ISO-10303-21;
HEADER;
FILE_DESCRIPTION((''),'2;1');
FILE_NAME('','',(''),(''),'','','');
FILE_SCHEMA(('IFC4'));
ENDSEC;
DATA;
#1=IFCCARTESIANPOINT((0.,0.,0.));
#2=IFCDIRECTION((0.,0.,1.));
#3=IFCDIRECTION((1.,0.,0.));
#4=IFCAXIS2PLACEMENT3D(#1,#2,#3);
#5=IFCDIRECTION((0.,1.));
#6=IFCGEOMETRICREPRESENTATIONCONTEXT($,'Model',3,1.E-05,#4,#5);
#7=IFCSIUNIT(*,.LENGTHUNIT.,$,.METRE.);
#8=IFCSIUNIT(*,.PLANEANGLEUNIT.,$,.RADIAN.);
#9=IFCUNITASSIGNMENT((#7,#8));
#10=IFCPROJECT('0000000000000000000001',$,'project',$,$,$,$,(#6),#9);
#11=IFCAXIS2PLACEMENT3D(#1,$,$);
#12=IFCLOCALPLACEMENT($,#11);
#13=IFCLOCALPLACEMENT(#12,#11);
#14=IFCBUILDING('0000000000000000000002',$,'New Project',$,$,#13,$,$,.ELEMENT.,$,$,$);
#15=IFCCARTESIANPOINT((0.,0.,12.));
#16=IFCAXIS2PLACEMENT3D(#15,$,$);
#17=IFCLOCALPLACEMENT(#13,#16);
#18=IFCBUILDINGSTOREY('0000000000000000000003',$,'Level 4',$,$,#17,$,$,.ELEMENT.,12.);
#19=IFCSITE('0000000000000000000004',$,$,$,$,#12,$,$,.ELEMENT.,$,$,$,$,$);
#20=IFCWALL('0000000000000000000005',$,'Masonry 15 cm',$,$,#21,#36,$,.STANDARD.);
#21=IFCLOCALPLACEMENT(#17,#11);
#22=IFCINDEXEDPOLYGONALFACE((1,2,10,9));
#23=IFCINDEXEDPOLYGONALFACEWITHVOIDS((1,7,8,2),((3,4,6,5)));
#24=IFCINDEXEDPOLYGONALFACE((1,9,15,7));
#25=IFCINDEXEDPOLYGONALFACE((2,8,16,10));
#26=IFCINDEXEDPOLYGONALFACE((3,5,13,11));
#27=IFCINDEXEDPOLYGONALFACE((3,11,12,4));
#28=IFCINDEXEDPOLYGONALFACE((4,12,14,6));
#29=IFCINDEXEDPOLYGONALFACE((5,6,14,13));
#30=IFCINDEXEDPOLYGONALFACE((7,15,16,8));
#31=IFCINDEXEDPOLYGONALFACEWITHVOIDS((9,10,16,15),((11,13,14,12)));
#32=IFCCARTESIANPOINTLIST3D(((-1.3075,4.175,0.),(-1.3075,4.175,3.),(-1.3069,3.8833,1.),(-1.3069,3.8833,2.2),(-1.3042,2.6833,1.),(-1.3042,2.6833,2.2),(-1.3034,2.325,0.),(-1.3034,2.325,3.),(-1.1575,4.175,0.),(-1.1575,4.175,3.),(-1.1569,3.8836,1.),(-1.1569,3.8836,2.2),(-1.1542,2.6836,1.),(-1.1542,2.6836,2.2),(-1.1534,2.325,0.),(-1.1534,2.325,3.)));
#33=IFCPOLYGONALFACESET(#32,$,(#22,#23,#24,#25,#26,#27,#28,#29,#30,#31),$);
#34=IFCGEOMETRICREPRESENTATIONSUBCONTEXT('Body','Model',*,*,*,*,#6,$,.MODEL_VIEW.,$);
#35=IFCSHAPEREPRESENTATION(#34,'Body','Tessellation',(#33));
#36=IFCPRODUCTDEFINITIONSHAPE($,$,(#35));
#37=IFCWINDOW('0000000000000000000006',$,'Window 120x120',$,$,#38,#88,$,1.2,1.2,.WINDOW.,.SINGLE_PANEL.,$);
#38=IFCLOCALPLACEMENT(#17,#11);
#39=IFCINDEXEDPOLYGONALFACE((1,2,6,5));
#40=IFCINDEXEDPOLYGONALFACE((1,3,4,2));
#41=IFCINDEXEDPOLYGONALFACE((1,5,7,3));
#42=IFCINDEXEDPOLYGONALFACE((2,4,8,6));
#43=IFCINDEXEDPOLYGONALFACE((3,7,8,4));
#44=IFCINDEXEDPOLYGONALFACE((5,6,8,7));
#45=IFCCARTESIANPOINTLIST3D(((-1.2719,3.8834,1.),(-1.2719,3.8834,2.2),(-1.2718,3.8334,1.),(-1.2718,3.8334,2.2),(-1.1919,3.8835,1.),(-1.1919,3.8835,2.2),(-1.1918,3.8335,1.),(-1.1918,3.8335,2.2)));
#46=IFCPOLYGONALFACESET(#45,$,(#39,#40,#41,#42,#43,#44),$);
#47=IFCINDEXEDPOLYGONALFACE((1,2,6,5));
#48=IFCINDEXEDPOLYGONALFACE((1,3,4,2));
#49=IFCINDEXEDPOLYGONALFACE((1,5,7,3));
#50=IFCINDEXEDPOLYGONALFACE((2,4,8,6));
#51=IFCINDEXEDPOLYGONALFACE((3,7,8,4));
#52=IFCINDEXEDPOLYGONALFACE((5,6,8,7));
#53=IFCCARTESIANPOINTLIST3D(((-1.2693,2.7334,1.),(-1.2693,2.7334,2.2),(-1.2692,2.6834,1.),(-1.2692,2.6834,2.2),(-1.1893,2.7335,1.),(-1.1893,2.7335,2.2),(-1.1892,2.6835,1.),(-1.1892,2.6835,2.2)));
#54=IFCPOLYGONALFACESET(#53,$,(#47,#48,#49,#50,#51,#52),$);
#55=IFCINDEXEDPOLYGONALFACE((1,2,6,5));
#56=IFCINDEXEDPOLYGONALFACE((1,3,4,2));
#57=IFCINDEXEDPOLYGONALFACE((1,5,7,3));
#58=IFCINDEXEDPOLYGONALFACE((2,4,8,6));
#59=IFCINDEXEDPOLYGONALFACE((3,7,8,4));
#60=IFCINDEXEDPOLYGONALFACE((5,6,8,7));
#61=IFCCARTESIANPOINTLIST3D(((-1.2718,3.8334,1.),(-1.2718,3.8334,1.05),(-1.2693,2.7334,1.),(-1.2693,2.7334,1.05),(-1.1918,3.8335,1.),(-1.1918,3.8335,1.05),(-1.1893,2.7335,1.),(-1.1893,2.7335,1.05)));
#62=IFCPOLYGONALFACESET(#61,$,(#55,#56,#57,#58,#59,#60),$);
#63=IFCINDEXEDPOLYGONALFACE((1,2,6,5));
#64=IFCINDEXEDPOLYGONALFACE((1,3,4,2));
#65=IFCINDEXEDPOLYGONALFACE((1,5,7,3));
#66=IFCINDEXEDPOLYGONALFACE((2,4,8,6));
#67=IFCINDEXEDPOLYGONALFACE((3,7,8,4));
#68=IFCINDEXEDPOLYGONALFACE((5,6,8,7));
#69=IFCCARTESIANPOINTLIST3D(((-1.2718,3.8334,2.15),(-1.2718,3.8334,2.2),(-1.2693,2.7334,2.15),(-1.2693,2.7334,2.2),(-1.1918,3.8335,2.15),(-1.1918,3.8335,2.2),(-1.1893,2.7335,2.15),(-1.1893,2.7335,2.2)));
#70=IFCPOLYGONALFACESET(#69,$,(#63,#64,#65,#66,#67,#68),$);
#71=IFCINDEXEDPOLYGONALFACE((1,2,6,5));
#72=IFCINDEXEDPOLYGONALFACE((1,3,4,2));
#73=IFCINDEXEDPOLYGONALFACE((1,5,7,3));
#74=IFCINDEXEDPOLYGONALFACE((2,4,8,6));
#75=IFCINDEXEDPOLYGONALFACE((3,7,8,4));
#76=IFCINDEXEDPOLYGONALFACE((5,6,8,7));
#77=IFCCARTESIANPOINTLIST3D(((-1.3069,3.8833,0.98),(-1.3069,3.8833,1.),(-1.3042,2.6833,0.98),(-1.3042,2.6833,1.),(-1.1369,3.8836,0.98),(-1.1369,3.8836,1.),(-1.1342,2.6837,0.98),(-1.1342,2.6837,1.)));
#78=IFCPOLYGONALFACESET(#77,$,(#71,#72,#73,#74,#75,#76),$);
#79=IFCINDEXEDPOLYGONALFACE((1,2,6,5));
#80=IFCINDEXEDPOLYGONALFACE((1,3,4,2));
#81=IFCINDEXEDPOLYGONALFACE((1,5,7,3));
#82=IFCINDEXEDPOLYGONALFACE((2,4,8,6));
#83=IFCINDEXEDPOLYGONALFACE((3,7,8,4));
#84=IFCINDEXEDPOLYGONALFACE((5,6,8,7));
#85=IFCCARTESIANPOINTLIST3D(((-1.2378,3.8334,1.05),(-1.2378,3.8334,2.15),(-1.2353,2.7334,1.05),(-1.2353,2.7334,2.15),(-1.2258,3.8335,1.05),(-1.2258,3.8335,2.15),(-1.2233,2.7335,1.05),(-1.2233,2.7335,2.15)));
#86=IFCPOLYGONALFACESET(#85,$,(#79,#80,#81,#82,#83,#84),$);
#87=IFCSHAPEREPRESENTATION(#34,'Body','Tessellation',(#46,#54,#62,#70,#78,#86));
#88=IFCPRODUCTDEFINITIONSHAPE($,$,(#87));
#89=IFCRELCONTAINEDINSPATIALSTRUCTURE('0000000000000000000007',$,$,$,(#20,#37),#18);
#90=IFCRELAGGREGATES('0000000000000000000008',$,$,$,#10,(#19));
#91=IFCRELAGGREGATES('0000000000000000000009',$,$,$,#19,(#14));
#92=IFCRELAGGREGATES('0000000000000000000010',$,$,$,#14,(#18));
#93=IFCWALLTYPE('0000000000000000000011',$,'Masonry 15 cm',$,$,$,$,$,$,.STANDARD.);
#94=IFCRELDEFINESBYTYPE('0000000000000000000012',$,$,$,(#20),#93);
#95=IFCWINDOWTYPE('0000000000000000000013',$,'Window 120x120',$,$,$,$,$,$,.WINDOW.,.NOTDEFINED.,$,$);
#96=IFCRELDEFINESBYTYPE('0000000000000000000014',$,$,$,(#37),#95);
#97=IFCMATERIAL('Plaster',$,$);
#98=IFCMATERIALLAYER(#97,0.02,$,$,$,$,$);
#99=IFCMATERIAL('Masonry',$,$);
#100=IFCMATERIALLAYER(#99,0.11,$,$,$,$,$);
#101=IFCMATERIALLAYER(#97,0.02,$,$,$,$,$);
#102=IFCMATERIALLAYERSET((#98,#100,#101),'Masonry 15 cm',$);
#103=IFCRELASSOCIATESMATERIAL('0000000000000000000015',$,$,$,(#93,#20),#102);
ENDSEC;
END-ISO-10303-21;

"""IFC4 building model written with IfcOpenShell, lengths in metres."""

from ifc_helpers import new_model, si_unit, direction, frame, frame_2d, origin, origin_with_axes, place, context, subcontext, project, spatial, polyline, rectangle, outline, extrude, material, layer, layer_set, layer_usage, type_object, element, fill, save


model = new_model("IFC4")

# Units and contexts
model_context = context("Model", 3, precision=1e-05, world=origin_with_axes(), true_north=direction((0.0, 1.0)))
body_context = subcontext(model_context, "Body", "Model", "MODEL_VIEW")
ifc_project = project(units=[si_unit("LENGTHUNIT", "METRE"), si_unit("PLANEANGLEUNIT", "RADIAN")], contexts=[model_context])

# Site, building, storey
site_placement = place(None, origin())
site = spatial("IfcSite", under=ifc_project, at=site_placement, CompositionType="ELEMENT")
building_placement = place(site_placement, origin())
building = spatial("IfcBuilding", under=site, at=building_placement, Name="New Project", CompositionType="ELEMENT")
storey_placement = place(building_placement, frame((0.0, 0.0, 12.0)))
storey = spatial("IfcBuildingStorey", under=building, at=storey_placement, Name="Level 4", CompositionType="ELEMENT", Elevation=12.0)

# Shared definitions
ifc_material_1 = material(Name="Plaster")
ifc_layer_1 = layer(ifc_material_1, 0.02)
ifc_material_2 = material(Name="Masonry")
ifc_layer_2 = layer(ifc_material_2, 0.11)
ifc_layer_3 = layer(ifc_material_1, 0.02)
ifc_layer_set_1 = layer_set([ifc_layer_1, ifc_layer_2, ifc_layer_3], Name="Masonry 15 cm")
ifc_layer_usage_1 = layer_usage(ifc_layer_set_1, "AXIS2", "NEGATIVE", 0.075)
wall_type = type_object("IfcWallType", Name="Masonry 15 cm", PredefinedType="STANDARD", material=ifc_layer_set_1)
window_type = type_object("IfcWindowType", Name="Window 120x120", PartitioningType="NOTDEFINED", PredefinedType="WINDOW")

# Wall, opening, window
wall_1_placement = place(storey_placement, frame((-1.2325, 4.175, 0.0), z_axis=(0.0, 0.0, 1.0), x_axis=(0.002207, -0.999998, 0.0)))
wall_1 = element("IfcWall", 1, at=wall_1_placement, inside=storey, type_object=wall_type, material=ifc_layer_usage_1, Name="Masonry 15 cm", PredefinedType="STANDARD", context=body_context, shape_type="SweptSolid", body=[
    extrude(outline(polyline([(-0.0002, -0.075), (1.8498, -0.075), (1.8502, 0.075), (0.0002, 0.075), (-0.0002, -0.075)])), origin(), (0.0, 0.0, 1.0), 3.0),
])
opening_1_placement = place(wall_1_placement, frame((0.2916, 0.0, 1.0)))
opening_1 = element("IfcOpeningElement", 2, at=opening_1_placement, cuts=wall_1, PredefinedType="OPENING", context=body_context, shape_type="SweptSolid", body=[
    extrude(rectangle(XDim=1.2, YDim=0.25, at=frame_2d((0.6, 0.0))), origin(), (0.0, 0.0, 1.0), 1.2),
])
window_1_placement = place(opening_1_placement, origin())
window_1 = element("IfcWindow", 3, at=window_1_placement, inside=storey, type_object=window_type, Name="Window 120x120", OverallHeight=1.2, OverallWidth=1.2, PartitioningType="SINGLE_PANEL", PredefinedType="WINDOW", context=body_context, shape_type="SweptSolid", body=[
    extrude(outline(polyline([(0.0, -0.04), (0.05, -0.04), (0.05, 0.04), (0.0, 0.04), (0.0, -0.04)])), origin(), (0.0, 0.0, 1.0), 1.2),
    extrude(outline(polyline([(1.15, -0.04), (1.2, -0.04), (1.2, 0.04), (1.15, 0.04), (1.15, -0.04)])), origin(), (0.0, 0.0, 1.0), 1.2),
    extrude(outline(polyline([(0.05, -0.04), (1.15, -0.04), (1.15, 0.04), (0.05, 0.04), (0.05, -0.04)])), origin(), (0.0, 0.0, 1.0), 0.05),
    extrude(outline(polyline([(0.05, -0.04), (1.15, -0.04), (1.15, 0.04), (0.05, 0.04), (0.05, -0.04)])), frame((0.0, 0.0, 1.15)), (0.0, 0.0, 1.0), 0.05),
    extrude(outline(polyline([(0.0, -0.075), (1.2, -0.075), (1.2, 0.095), (0.0, 0.095), (0.0, -0.075)])), frame((0.0, 0.0, -0.02)), (0.0, 0.0, 1.0), 0.02),
    extrude(outline(polyline([(0.05, -0.006), (1.15, -0.006), (1.15, 0.006), (0.05, 0.006), (0.05, -0.006)])), frame((0.0, 0.0, 0.05)), (0.0, 0.0, 1.0), 1.1),
])
fill(opening_1, window_1)

save(model, "model.ifc")
